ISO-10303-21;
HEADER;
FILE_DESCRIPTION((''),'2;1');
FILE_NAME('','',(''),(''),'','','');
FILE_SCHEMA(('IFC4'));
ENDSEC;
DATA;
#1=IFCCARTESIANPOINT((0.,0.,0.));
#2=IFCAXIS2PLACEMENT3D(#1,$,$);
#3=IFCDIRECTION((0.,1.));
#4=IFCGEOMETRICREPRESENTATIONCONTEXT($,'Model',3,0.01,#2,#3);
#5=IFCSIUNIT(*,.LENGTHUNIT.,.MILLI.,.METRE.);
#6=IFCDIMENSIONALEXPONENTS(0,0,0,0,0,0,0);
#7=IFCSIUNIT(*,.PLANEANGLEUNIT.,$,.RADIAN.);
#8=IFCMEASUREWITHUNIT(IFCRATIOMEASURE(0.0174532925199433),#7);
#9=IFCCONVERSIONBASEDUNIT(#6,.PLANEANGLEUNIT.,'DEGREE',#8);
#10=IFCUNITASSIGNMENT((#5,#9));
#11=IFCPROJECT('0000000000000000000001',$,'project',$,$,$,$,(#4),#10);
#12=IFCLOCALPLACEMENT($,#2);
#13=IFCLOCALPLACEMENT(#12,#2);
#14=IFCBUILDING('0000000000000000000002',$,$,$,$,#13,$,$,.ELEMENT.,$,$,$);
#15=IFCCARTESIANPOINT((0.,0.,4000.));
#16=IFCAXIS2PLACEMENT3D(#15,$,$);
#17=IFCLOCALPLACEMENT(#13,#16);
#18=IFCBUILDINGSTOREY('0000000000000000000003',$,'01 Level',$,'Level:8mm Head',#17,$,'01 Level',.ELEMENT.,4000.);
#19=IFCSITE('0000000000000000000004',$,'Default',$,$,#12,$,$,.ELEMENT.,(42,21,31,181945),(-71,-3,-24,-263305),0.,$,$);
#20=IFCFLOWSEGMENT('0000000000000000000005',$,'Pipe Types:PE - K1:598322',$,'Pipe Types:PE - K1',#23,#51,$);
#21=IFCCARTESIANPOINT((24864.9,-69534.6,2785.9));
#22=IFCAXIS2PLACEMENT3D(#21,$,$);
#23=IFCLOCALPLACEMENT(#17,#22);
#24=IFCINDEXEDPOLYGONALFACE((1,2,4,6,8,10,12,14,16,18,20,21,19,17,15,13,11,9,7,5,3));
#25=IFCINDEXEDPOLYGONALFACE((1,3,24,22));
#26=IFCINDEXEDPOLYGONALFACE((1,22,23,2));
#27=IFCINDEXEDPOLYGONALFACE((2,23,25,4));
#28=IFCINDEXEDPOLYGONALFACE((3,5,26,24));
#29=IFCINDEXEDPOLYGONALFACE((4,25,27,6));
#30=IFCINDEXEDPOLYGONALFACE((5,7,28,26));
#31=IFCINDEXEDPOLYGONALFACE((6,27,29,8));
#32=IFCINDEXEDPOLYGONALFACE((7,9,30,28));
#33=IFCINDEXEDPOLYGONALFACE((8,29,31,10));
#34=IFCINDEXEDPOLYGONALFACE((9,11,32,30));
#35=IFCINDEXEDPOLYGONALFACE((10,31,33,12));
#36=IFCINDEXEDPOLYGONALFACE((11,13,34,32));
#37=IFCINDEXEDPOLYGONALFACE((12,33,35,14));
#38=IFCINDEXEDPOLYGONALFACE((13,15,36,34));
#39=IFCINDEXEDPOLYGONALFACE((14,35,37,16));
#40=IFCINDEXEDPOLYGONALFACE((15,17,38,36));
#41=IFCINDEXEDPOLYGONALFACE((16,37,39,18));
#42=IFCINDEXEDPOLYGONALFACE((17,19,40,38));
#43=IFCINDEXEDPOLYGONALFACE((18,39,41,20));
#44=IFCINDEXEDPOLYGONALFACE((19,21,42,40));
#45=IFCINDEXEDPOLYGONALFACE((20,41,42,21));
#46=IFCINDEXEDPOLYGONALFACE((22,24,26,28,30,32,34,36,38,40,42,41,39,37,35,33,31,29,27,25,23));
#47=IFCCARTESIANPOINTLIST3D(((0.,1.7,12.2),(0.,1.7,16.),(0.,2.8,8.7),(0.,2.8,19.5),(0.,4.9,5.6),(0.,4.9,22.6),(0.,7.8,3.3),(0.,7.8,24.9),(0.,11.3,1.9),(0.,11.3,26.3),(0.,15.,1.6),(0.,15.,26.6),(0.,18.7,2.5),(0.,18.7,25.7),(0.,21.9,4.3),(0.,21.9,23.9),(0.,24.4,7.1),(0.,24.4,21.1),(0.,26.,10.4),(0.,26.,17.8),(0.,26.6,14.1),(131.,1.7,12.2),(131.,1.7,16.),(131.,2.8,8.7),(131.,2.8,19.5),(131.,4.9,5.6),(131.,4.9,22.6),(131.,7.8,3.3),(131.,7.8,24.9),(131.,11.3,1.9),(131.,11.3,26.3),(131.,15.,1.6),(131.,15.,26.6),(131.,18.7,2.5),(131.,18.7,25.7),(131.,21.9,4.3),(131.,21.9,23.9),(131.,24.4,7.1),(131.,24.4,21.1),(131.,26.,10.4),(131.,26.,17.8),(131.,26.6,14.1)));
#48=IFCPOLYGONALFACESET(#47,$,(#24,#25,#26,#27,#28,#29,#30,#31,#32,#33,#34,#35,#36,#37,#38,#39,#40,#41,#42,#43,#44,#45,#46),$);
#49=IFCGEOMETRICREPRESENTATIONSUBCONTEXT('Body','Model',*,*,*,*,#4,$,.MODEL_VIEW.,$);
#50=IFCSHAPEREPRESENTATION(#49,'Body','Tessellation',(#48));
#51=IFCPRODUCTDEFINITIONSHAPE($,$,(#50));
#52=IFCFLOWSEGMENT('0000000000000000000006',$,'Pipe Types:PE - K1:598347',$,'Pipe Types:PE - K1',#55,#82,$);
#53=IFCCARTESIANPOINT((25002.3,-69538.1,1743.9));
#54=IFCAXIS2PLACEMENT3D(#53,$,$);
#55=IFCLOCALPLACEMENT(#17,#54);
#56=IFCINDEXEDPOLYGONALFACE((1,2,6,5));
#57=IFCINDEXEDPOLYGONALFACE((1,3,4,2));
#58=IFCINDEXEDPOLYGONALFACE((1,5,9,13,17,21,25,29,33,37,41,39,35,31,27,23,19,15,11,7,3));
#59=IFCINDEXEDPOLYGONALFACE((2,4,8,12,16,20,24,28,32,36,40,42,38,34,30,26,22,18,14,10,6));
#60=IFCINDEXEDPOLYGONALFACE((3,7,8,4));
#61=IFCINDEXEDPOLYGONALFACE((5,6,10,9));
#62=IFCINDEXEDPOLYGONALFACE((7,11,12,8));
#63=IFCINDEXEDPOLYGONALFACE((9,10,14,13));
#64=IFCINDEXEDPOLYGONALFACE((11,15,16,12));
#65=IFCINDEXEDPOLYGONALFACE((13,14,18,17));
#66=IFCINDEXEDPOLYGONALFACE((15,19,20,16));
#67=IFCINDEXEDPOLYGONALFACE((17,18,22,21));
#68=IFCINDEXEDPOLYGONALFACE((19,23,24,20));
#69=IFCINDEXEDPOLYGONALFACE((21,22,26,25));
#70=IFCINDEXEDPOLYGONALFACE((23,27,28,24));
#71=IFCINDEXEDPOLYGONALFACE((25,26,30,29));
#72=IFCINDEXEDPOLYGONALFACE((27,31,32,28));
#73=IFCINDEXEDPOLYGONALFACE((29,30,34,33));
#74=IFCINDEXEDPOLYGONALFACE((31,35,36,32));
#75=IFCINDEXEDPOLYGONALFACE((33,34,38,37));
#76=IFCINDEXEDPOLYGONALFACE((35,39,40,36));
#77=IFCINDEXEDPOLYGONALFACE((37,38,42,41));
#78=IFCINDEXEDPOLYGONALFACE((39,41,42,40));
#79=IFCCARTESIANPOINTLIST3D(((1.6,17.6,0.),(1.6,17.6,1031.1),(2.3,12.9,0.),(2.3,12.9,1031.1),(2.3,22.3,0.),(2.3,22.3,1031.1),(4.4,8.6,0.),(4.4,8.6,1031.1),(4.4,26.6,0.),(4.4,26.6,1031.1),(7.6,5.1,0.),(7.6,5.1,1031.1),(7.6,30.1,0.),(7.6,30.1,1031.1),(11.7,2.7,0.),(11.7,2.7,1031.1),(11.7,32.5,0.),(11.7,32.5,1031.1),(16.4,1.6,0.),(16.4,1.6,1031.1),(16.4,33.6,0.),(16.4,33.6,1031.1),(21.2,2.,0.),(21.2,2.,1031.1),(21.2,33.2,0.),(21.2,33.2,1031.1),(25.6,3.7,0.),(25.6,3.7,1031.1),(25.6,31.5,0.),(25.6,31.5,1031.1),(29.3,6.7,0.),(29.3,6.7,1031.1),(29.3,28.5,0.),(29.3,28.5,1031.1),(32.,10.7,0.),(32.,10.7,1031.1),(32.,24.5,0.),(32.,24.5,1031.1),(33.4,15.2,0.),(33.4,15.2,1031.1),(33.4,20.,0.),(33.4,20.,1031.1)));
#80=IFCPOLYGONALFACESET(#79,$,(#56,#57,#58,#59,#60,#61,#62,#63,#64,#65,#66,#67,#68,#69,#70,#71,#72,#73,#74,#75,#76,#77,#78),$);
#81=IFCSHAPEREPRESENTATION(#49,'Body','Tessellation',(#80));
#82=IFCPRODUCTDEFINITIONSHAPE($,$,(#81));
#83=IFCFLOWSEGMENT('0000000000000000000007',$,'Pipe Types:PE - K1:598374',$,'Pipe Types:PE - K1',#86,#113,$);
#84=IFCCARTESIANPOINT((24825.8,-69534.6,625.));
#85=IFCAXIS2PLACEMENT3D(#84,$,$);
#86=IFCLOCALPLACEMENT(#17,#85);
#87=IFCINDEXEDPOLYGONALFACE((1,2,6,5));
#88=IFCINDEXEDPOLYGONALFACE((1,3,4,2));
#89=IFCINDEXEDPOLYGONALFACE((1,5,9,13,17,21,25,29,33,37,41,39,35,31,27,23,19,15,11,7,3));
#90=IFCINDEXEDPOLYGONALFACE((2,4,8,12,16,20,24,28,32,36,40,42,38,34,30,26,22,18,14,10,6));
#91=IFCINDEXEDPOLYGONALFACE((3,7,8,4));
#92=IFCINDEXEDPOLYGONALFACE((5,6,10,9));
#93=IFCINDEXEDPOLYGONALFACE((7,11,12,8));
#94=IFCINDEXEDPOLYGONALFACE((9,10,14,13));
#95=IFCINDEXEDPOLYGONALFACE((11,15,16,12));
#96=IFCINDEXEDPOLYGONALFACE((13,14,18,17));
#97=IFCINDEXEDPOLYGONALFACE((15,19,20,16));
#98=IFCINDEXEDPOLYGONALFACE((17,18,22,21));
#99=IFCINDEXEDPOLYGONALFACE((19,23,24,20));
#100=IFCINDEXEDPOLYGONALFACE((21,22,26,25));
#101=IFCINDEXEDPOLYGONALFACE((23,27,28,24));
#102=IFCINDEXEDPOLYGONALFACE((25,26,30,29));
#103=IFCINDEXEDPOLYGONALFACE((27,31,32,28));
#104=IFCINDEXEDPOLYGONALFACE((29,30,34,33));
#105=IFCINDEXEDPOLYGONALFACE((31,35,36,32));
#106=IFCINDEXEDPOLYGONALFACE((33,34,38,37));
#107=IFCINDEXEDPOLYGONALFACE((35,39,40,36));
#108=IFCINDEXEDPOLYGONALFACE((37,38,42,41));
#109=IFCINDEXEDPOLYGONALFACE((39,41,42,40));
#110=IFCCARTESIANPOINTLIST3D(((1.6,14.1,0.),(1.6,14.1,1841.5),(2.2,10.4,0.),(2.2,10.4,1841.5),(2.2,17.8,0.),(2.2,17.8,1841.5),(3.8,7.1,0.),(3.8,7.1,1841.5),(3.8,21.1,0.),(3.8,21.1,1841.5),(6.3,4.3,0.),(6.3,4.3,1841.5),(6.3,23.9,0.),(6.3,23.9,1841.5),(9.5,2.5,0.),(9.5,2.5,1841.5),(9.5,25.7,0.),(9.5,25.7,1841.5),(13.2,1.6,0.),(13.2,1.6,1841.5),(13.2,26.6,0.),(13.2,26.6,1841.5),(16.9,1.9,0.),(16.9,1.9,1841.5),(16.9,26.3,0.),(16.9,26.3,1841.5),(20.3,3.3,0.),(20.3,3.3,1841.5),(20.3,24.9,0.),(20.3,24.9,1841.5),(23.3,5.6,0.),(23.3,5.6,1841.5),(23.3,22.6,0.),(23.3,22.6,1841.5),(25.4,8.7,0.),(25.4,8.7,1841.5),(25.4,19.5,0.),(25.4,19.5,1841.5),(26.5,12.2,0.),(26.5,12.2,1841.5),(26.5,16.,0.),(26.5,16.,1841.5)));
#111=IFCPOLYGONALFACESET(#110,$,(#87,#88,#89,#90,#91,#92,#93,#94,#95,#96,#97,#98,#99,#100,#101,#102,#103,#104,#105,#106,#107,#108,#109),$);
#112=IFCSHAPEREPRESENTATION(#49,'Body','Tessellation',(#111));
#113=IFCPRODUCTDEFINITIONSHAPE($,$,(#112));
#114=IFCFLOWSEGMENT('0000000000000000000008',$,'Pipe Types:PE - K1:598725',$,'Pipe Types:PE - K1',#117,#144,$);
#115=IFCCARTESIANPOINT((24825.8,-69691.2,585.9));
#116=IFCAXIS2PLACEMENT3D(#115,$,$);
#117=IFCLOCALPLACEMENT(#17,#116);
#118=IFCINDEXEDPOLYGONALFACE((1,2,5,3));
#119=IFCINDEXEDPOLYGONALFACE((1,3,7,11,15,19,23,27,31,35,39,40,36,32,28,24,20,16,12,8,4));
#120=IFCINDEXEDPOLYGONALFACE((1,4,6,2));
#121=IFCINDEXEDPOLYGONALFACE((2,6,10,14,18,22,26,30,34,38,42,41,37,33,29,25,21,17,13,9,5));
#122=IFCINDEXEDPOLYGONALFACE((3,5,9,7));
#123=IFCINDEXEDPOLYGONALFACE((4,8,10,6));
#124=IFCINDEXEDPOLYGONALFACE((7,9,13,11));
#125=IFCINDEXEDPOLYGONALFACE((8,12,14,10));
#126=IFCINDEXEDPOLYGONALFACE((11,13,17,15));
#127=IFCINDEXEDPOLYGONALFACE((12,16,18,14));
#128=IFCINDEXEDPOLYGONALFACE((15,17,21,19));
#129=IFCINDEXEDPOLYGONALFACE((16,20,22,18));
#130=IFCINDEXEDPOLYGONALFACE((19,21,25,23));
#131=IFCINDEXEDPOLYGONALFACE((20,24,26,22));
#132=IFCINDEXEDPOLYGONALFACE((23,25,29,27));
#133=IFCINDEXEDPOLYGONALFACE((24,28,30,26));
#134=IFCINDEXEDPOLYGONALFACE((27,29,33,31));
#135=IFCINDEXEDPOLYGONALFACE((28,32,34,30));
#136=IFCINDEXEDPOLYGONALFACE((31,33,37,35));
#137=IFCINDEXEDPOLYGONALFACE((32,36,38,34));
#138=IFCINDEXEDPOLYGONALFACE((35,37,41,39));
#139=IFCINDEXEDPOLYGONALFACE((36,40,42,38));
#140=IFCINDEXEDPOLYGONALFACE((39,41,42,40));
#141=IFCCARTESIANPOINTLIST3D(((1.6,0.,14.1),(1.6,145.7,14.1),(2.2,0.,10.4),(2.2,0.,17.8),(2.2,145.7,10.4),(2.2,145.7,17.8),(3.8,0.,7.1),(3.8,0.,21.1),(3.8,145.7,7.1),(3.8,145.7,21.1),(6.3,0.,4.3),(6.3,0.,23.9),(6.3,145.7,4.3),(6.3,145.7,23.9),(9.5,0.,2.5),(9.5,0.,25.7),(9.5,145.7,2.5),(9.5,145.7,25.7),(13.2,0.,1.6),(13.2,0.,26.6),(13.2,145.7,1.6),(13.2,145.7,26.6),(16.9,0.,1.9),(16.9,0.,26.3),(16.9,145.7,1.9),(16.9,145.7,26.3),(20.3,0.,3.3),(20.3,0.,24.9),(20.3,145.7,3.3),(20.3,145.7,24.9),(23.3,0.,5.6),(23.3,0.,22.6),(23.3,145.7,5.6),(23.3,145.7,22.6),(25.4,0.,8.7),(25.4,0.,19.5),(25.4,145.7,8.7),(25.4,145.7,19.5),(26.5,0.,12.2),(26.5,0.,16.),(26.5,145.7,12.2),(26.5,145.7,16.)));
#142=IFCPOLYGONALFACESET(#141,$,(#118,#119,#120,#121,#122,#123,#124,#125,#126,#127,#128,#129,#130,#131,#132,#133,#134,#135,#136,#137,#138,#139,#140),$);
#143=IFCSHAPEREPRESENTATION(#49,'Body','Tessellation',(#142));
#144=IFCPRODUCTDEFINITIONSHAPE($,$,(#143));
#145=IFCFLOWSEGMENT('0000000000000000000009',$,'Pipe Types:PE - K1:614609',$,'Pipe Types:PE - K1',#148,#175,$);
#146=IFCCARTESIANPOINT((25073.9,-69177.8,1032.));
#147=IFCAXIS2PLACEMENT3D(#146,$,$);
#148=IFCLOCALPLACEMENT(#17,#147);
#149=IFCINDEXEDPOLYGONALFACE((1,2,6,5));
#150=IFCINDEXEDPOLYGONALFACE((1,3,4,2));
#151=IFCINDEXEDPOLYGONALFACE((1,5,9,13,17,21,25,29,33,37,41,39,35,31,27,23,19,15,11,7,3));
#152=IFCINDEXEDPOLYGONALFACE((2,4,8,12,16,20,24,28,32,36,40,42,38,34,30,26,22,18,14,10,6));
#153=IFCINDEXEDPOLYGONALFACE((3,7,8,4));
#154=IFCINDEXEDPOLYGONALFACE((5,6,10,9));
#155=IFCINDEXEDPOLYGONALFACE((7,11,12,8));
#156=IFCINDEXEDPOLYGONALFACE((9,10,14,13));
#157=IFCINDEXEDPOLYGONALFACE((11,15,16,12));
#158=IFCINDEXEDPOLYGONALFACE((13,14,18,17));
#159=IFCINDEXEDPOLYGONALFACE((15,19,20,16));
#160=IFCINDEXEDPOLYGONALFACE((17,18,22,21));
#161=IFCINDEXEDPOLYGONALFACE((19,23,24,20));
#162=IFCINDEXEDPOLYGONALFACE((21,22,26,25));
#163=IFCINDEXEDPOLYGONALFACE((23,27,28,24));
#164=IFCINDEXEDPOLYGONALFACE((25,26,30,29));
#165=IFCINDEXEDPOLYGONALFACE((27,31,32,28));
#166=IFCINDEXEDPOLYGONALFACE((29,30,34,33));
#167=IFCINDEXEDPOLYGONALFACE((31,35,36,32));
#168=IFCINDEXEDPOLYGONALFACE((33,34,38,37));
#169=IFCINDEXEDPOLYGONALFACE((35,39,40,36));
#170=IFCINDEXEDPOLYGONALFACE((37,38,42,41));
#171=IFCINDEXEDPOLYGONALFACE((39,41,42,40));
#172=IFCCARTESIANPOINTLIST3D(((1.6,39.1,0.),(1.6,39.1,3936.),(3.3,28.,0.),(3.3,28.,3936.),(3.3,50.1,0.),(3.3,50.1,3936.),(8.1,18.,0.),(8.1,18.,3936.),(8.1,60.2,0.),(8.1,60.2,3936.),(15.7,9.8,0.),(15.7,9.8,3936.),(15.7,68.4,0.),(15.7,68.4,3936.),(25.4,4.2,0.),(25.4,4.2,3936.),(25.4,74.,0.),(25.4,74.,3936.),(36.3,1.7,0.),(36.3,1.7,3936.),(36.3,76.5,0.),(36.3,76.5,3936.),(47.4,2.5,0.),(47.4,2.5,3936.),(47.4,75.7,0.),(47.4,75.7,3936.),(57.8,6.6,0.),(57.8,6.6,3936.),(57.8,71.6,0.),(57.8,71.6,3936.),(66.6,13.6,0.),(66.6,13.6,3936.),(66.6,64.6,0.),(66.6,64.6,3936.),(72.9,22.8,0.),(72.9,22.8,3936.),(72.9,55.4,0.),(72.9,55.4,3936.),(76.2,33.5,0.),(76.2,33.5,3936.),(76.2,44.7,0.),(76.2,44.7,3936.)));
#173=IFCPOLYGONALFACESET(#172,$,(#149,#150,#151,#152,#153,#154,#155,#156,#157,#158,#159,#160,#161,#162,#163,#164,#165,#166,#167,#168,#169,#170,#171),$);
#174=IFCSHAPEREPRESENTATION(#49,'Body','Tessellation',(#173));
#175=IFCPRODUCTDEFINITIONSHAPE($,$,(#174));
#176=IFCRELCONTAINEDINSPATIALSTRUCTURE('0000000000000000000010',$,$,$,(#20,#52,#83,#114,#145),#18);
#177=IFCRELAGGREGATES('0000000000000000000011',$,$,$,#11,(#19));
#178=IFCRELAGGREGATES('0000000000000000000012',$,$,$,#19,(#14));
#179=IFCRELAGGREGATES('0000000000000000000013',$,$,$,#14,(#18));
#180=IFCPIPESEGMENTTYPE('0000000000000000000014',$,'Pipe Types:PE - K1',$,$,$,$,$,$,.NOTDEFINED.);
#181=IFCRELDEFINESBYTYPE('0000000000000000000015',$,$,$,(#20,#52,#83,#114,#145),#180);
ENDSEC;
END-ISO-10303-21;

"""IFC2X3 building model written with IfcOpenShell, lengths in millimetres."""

from ifc_helpers import new_model, entity, si_unit, converted_unit, direction, frame, frame_2d, origin, origin_2d_with_axis, place, context, subcontext, project, spatial, circle, extrude, type_object, element, save


model = new_model("IFC2X3")

# Units and contexts
model_context = context("Model", 3, precision=0.01, world=origin(), true_north=direction((0.0, 1.0)))
body_context = subcontext(model_context, "Body", "Model", "MODEL_VIEW")
ifc_project = project(units=[si_unit("LENGTHUNIT", "METRE", prefix="MILLI"), converted_unit("PLANEANGLEUNIT", "DEGREE", entity("IfcRatioMeasure", 0.0174532925199433), si_unit("PLANEANGLEUNIT", "RADIAN"), dimensions=[0, 0, 0, 0, 0, 0, 0])], contexts=[model_context])

# Site, building, storey
site_placement = place(None, origin())
site = spatial("IfcSite", under=ifc_project, at=site_placement, Name="Default", CompositionType="ELEMENT", RefLatitude=(42, 21, 31, 181945), RefLongitude=(-71, -3, -24, -263305), RefElevation=0.0)
building_placement = place(site_placement, origin())
building = spatial("IfcBuilding", under=site, at=building_placement, CompositionType="ELEMENT")
storey_placement = place(building_placement, frame((0.0, 0.0, 4000.0)))
storey = spatial("IfcBuildingStorey", under=building, at=storey_placement, Name="01 Level", ObjectType="Level:8mm Head", LongName="01 Level", CompositionType="ELEMENT", Elevation=4000.0)

# Flow segments
pipe_segment_type = type_object("IfcPipeSegmentType", Name="Pipe Types:PE - K1", PredefinedType="NOTDEFINED")
flow_segment_1_placement = place(storey_placement, frame((24864.9, -69534.6, 2785.9)))
element("IfcFlowSegment", 1, at=flow_segment_1_placement, inside=storey, type_object=pipe_segment_type, Name="Pipe Types:PE - K1:598322", ObjectType="Pipe Types:PE - K1", context=body_context, shape_type="SweptSolid", body=[
    extrude(circle(Radius=12.5, at=origin_2d_with_axis()), frame((0.0, 14.1, 14.1), z_axis=(1.0, 0.0, 0.0), x_axis=(0.0, 1.0, 0.0)), (0.0, 0.0, 1.0), 131.0),
])
flow_segment_2_placement = place(storey_placement, frame((25002.3, -69538.1, 1743.9)))
element("IfcFlowSegment", 2, at=flow_segment_2_placement, inside=storey, type_object=pipe_segment_type, Name="Pipe Types:PE - K1:598347", ObjectType="Pipe Types:PE - K1", context=body_context, shape_type="SweptSolid", body=[
    extrude(circle(Radius=16.0, at=origin_2d_with_axis()), frame((17.6, 17.6, 0.0), z_axis=(0.0, 0.0, 1.0), x_axis=(-1.0, 0.0, 0.0)), (0.0, 0.0, 1.0), 1031.1),
])
flow_segment_3_placement = place(storey_placement, frame((24825.8, -69534.6, 625.0)))
element("IfcFlowSegment", 3, at=flow_segment_3_placement, inside=storey, type_object=pipe_segment_type, Name="Pipe Types:PE - K1:598374", ObjectType="Pipe Types:PE - K1", context=body_context, shape_type="SweptSolid", body=[
    extrude(circle(Radius=12.5, at=origin_2d_with_axis()), frame((14.1, 14.1, 0.0), z_axis=(0.0, 0.0, 1.0), x_axis=(-1.0, 0.0, 0.0)), (0.0, 0.0, 1.0), 1841.5),
])
flow_segment_4_placement = place(storey_placement, frame((24825.8, -69691.2, 585.9)))
element("IfcFlowSegment", 4, at=flow_segment_4_placement, inside=storey, type_object=pipe_segment_type, Name="Pipe Types:PE - K1:598725", ObjectType="Pipe Types:PE - K1", context=body_context, shape_type="SweptSolid", body=[
    extrude(circle(Radius=12.5, at=frame_2d((0.0, 0.0), x_axis=(1.0, 0.0))), frame((14.1, 0.0, 14.1), z_axis=(0.0, 1.0, 0.0), x_axis=(-1.0, 0.0, 0.0)), (0.0, 0.0, 1.0), 145.7),
])
flow_segment_5_placement = place(storey_placement, frame((25073.9, -69177.8, 1032.0)))
element("IfcFlowSegment", 5, at=flow_segment_5_placement, inside=storey, type_object=pipe_segment_type, Name="Pipe Types:PE - K1:614609", ObjectType="Pipe Types:PE - K1", context=body_context, shape_type="SweptSolid", body=[
    extrude(circle(Radius=37.5, at=origin_2d_with_axis()), frame((39.1, 39.1, 0.0), z_axis=(0.0, 0.0, 1.0), x_axis=(-1.0, 0.0, 0.0)), (0.0, 0.0, 1.0), 3936.0),
])

save(model, "model.ifc")
